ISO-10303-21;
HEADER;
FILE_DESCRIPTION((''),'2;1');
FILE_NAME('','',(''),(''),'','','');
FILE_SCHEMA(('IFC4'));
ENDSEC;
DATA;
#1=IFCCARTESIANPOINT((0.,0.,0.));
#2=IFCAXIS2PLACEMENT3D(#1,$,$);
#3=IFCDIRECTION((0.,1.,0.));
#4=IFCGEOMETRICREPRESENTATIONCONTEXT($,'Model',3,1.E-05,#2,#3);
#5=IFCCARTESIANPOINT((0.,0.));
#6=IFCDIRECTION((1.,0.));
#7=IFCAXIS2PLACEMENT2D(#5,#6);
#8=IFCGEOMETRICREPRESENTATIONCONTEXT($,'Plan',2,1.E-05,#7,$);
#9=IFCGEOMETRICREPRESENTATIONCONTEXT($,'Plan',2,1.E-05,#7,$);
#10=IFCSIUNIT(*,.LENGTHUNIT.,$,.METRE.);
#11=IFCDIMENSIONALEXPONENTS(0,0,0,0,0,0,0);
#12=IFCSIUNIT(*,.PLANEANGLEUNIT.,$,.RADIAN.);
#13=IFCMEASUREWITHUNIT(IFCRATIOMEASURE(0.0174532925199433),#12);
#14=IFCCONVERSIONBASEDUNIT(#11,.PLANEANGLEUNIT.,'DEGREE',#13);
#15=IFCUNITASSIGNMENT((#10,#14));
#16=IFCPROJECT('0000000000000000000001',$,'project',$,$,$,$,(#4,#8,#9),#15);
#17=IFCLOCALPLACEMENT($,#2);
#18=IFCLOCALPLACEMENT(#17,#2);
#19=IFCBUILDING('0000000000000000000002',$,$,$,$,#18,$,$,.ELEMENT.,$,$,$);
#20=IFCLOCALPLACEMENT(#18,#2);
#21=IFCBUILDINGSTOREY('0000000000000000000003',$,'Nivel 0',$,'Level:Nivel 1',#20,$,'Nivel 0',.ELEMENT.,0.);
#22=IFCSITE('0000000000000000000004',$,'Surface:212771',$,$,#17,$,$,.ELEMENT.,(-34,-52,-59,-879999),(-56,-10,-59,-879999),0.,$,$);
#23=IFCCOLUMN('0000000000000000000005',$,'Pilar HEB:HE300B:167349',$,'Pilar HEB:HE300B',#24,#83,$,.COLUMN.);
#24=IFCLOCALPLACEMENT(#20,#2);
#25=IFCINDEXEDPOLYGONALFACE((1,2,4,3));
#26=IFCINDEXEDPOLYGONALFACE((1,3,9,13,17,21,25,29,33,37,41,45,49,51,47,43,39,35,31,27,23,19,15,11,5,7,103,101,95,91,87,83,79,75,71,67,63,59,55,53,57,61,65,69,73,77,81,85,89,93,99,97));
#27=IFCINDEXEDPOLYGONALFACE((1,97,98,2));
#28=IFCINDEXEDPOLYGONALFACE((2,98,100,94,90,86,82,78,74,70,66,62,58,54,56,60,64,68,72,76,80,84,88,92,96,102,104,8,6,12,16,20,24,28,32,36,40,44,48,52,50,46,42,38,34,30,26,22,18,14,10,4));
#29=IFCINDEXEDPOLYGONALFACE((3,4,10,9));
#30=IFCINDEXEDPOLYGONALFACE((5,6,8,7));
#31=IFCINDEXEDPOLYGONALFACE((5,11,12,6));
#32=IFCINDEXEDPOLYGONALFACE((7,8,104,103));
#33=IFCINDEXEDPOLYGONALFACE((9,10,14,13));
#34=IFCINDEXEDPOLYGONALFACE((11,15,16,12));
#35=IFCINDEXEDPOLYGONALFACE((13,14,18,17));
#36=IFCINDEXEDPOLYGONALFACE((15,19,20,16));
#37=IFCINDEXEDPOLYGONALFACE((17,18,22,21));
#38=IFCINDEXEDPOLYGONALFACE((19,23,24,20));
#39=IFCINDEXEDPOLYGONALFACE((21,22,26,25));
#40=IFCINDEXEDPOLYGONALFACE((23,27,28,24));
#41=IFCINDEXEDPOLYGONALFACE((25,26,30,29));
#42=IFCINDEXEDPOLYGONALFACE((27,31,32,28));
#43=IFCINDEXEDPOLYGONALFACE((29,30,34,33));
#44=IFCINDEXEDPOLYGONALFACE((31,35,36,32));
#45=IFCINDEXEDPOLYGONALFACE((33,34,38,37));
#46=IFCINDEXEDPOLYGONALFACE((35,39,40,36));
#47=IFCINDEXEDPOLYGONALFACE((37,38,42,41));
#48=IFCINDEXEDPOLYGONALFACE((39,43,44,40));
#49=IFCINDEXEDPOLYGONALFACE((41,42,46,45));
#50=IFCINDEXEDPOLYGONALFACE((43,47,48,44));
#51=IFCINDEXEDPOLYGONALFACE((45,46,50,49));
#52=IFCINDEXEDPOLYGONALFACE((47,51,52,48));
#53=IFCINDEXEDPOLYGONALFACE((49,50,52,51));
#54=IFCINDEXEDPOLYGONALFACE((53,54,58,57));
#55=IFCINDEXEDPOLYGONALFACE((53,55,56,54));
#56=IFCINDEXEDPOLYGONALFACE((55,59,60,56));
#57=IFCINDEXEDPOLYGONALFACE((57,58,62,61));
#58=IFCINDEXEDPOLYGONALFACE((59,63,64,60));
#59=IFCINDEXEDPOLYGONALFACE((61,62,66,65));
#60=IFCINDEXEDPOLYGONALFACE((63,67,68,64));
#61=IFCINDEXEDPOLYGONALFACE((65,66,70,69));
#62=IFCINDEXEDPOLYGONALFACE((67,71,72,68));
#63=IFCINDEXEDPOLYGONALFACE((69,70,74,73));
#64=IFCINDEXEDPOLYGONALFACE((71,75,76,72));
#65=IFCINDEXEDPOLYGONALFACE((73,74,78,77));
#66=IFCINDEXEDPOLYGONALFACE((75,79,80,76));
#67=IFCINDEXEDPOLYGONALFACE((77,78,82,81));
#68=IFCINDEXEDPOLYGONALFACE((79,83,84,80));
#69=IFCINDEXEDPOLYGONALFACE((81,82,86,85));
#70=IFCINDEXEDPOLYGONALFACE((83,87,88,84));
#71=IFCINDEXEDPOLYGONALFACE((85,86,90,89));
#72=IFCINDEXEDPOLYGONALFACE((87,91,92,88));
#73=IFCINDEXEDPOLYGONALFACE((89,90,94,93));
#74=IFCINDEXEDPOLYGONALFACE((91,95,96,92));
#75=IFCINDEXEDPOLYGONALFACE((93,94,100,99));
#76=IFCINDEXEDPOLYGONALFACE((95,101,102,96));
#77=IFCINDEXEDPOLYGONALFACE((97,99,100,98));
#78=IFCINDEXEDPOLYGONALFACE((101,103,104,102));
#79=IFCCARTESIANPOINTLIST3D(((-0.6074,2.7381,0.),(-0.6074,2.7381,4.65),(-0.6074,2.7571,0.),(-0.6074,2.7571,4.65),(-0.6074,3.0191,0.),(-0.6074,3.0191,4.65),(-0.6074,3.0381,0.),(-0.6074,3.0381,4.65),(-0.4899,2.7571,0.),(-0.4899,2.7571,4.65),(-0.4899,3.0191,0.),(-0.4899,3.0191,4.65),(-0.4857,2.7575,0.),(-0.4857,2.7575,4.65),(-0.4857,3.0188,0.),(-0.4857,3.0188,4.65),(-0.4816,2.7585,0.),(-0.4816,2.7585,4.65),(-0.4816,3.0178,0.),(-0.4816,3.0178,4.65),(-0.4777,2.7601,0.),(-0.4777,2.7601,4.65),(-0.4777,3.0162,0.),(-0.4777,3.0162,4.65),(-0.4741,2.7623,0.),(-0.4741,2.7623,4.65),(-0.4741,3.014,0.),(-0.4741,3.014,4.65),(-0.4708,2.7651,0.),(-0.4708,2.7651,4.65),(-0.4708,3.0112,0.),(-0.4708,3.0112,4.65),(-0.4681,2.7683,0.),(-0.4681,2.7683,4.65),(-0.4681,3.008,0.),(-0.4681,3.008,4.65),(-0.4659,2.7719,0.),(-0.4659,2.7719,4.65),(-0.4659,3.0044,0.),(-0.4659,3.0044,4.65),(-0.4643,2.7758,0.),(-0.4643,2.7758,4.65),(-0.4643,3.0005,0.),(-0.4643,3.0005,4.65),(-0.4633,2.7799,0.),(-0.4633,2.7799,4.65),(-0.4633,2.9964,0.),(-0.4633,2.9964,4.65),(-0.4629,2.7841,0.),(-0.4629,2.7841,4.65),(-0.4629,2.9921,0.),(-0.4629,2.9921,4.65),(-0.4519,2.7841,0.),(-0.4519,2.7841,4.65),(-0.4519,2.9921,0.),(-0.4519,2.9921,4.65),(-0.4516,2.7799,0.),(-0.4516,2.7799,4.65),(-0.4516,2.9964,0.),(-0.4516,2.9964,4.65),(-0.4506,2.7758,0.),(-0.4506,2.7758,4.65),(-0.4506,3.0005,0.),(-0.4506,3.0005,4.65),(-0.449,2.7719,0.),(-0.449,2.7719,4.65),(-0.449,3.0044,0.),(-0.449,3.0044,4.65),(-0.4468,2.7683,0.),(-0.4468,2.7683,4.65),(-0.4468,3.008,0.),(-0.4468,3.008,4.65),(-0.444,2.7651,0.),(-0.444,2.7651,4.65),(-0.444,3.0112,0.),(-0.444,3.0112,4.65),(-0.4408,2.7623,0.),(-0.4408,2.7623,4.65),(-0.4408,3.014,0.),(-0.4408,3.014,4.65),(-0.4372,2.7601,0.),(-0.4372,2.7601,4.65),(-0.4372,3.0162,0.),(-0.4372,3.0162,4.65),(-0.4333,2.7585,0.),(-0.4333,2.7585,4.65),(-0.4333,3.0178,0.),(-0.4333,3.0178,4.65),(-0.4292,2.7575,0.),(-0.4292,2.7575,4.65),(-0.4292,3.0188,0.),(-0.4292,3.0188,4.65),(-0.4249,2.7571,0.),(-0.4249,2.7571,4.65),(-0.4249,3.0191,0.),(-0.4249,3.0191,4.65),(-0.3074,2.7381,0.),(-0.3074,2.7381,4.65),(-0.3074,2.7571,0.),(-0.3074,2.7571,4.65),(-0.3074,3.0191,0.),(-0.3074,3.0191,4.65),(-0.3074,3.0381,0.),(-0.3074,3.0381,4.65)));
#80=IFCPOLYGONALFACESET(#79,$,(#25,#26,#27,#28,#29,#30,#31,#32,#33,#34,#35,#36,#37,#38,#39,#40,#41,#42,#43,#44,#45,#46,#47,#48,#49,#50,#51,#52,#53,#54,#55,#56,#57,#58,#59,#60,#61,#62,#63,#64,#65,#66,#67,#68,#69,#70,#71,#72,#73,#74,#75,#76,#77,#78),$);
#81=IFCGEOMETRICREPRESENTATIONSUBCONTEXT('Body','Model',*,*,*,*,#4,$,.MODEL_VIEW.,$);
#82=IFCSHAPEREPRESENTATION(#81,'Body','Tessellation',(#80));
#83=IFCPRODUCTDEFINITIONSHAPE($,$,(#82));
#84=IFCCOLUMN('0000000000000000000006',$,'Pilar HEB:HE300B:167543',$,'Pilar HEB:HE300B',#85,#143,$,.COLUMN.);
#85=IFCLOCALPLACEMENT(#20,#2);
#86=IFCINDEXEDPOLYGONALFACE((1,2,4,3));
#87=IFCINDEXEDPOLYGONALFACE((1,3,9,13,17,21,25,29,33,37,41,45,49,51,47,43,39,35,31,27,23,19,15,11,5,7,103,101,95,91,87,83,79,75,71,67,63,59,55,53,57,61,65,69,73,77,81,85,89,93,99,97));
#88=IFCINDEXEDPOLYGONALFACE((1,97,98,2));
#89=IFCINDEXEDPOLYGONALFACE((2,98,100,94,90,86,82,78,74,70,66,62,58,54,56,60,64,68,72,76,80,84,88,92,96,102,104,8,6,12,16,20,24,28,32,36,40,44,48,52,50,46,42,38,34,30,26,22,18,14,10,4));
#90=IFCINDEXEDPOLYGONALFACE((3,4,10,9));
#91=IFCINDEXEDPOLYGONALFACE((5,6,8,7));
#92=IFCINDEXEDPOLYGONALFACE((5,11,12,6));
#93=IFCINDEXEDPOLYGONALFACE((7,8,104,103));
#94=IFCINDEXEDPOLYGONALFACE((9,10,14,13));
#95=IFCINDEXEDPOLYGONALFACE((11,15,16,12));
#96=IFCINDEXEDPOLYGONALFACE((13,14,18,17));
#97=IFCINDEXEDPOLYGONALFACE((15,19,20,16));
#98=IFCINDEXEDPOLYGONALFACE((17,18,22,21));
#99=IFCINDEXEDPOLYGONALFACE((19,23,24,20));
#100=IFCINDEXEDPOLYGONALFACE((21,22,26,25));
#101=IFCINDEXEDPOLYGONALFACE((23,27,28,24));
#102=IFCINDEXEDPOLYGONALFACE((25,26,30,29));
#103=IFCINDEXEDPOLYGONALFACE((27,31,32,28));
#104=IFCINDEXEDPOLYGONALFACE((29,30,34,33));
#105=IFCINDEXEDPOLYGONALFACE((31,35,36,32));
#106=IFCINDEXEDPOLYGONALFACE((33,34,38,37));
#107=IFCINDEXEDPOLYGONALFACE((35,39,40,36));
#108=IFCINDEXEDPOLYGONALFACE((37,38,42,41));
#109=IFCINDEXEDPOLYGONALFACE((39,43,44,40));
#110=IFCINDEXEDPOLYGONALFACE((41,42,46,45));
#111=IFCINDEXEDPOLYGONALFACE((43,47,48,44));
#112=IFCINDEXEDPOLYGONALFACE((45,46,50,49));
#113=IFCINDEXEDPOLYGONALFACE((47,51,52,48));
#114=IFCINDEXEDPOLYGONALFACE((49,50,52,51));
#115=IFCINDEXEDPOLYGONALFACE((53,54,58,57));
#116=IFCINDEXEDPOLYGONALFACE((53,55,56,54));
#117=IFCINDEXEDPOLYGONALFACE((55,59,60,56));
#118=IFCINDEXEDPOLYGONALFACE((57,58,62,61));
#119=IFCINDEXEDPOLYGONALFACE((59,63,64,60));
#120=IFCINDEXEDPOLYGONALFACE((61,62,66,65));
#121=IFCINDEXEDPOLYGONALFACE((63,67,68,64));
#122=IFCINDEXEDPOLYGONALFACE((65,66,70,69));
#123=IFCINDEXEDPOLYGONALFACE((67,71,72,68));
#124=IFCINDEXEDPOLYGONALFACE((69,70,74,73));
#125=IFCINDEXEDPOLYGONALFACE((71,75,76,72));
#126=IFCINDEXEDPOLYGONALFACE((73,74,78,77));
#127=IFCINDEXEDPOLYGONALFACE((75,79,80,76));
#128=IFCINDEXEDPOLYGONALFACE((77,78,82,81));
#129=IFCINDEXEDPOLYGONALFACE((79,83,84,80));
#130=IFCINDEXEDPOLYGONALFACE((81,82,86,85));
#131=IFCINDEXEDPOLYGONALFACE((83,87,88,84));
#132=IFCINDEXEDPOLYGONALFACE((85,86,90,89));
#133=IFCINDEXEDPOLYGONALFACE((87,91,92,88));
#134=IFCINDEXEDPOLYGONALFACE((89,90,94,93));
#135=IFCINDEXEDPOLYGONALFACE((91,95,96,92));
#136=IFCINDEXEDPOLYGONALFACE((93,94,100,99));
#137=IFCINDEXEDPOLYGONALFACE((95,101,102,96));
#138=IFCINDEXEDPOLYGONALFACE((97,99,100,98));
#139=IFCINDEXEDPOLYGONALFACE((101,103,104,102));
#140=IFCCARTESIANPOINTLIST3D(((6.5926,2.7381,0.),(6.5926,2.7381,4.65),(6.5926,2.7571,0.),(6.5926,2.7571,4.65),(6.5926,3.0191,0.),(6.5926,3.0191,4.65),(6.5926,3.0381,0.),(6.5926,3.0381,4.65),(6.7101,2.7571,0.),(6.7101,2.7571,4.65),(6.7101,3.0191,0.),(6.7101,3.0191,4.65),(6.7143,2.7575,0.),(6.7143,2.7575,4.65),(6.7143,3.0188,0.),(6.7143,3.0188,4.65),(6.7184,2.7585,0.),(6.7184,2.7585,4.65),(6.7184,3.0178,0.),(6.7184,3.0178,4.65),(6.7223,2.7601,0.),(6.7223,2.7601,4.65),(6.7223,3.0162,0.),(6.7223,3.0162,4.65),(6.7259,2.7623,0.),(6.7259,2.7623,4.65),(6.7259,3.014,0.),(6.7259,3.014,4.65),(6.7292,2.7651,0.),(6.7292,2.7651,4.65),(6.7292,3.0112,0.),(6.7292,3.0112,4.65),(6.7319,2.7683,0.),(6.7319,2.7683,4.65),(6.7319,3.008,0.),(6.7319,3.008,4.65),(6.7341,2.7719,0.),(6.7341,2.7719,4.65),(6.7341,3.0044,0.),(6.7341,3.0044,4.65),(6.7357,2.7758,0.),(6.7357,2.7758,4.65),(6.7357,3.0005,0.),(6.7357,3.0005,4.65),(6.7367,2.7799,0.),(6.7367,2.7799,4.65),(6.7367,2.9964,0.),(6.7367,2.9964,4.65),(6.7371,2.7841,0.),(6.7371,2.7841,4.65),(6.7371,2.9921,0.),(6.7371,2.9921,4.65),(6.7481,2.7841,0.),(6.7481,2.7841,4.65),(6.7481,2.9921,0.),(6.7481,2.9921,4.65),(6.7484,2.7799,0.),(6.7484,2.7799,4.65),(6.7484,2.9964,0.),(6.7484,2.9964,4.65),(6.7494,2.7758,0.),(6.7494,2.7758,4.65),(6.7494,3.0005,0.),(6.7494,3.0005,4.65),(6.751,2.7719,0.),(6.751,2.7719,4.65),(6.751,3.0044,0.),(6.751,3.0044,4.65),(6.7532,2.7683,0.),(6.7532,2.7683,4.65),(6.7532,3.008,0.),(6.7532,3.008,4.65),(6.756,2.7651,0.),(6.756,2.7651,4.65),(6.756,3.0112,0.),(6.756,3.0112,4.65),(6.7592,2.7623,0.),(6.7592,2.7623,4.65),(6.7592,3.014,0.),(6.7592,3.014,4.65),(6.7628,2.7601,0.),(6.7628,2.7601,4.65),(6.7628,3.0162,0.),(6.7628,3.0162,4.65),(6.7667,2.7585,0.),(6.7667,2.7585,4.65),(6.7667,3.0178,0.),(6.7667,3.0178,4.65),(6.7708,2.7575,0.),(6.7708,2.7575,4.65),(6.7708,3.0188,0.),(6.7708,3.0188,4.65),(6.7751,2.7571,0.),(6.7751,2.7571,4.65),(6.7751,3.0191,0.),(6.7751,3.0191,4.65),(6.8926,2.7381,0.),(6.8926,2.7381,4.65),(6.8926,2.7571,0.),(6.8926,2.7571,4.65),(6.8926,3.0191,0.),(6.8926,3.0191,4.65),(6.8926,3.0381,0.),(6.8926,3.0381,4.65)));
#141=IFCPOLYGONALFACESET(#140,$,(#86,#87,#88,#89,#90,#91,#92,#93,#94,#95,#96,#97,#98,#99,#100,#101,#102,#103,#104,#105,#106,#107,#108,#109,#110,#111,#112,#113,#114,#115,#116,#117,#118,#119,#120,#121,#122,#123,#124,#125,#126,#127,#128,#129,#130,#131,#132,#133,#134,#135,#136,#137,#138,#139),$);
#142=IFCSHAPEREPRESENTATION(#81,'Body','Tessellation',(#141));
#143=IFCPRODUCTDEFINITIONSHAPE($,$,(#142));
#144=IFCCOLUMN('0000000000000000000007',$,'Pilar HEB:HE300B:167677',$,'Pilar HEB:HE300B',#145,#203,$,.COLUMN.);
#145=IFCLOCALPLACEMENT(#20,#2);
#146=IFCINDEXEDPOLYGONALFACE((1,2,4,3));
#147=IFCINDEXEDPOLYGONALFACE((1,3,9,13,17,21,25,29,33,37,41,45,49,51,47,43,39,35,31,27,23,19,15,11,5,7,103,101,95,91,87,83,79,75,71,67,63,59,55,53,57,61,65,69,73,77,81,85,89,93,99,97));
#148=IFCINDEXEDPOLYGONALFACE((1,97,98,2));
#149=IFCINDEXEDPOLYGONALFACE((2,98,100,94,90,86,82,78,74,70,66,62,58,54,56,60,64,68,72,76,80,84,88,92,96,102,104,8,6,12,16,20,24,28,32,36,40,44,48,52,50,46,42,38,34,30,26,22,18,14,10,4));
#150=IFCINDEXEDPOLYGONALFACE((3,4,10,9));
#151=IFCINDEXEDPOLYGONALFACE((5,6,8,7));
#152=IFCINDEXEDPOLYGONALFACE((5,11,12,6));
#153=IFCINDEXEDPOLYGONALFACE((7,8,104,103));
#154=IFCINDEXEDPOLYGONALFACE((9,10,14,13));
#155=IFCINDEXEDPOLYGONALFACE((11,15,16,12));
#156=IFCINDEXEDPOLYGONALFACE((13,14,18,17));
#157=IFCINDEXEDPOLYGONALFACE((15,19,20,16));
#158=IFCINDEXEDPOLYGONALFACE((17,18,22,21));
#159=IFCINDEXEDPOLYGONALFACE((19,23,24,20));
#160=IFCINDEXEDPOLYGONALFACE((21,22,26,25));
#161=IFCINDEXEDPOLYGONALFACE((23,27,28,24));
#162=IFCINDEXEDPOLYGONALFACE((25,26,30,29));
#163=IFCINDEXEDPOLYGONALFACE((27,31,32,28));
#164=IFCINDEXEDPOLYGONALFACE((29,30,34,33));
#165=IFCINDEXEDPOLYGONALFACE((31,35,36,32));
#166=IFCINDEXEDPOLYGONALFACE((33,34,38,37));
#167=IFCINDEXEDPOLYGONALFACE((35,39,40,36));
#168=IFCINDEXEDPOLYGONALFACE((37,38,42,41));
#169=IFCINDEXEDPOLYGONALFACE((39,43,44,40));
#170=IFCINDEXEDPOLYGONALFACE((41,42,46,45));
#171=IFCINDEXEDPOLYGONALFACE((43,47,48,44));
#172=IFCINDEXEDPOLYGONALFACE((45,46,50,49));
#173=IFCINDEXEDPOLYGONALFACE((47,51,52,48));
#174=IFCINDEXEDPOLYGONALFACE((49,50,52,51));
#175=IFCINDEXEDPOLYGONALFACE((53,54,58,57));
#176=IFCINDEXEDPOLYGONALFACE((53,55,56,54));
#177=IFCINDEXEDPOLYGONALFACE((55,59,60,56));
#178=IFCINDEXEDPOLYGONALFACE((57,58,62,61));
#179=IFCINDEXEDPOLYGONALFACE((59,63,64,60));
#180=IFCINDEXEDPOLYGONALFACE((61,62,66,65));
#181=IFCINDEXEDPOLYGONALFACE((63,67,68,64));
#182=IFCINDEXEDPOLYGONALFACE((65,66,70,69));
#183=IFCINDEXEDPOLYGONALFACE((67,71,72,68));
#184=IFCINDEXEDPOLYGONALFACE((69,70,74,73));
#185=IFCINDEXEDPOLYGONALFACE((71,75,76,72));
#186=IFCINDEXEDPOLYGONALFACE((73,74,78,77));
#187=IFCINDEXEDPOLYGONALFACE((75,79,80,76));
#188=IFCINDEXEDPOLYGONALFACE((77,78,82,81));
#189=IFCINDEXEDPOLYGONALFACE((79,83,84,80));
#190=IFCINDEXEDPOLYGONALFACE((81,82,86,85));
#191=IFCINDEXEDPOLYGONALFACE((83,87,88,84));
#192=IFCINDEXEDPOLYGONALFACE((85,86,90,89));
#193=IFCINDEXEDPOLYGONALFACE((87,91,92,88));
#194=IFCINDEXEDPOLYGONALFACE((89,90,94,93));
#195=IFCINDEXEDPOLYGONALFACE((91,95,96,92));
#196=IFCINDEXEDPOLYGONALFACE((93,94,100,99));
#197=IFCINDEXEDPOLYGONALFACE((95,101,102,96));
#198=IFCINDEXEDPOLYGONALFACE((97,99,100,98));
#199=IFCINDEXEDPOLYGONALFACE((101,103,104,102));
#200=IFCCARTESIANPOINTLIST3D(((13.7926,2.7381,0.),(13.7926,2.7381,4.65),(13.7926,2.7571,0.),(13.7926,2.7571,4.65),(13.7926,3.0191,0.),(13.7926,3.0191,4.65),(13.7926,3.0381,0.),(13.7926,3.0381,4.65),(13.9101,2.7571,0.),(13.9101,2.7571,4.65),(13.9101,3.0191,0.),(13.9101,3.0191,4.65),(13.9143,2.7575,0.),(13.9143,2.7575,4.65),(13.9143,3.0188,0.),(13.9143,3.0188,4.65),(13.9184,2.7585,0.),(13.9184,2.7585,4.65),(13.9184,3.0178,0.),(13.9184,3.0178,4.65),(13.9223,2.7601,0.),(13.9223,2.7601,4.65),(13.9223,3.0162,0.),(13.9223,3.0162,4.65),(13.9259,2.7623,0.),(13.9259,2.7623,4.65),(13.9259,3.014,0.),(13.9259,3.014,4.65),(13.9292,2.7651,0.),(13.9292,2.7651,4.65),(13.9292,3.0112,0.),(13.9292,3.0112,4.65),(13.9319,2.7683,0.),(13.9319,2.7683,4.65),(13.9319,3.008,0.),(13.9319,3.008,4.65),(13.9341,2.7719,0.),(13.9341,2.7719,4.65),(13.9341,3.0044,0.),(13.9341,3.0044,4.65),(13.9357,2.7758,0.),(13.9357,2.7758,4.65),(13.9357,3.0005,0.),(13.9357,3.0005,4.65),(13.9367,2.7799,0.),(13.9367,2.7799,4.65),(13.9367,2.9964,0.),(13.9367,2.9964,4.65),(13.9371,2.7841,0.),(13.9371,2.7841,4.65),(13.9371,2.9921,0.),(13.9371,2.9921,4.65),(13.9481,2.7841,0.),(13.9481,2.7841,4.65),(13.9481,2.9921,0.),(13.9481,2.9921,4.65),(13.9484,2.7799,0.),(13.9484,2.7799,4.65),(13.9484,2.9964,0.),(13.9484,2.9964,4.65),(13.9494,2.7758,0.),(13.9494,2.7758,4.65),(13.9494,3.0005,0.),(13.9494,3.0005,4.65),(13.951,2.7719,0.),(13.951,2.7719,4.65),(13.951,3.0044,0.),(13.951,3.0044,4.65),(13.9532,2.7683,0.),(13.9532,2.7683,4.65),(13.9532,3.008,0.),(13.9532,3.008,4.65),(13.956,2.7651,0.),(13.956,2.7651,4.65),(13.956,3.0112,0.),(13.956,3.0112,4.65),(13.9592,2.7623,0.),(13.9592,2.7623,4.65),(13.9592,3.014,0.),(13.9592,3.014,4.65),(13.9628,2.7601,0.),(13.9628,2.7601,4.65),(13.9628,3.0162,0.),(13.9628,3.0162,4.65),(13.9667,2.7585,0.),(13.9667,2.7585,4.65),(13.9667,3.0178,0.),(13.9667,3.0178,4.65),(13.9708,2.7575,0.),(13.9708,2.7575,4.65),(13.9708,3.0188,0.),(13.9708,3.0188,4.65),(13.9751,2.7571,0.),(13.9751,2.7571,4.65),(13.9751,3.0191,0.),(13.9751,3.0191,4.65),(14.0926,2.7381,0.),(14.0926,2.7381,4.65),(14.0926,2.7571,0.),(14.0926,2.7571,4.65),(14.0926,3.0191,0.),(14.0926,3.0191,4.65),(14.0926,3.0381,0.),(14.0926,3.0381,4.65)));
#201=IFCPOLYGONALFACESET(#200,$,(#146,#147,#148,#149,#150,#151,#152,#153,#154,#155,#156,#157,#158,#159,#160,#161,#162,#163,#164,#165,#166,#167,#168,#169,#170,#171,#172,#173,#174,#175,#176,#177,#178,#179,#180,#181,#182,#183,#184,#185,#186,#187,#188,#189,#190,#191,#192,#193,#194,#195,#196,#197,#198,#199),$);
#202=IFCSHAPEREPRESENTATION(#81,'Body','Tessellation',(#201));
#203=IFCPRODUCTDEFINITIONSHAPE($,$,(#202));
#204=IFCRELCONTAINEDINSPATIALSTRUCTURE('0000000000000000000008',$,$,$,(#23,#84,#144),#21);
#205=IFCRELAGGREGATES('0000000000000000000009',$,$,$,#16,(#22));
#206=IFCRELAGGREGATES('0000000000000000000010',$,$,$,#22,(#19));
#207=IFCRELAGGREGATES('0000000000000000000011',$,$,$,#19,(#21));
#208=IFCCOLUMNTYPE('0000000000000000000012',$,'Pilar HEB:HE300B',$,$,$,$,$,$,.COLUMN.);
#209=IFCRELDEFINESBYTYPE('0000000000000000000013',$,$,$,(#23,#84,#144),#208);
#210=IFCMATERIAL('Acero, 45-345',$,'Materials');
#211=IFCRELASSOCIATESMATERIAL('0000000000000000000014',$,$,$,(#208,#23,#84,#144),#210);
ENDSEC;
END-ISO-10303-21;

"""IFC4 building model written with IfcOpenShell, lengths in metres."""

from ifc_helpers import new_model, entity, si_unit, converted_unit, direction, frame, origin, origin_2d_with_axis, place, context, subcontext, project, spatial, indexed_curve, outline, extrude, source, transform, mapped, material, type_object, type_shapes, element, save


model = new_model("IFC4")

# Units and contexts
model_context = context("Model", 3, precision=1e-05, world=origin(), true_north=direction((0.0, 1.0, 0.0)))
plan_context_1 = context("Plan", 2, precision=1e-05, world=origin_2d_with_axis())
plan_context_2 = context("Plan", 2, precision=1e-05, world=origin_2d_with_axis())
body_context = subcontext(model_context, "Body", "Model", "MODEL_VIEW")
ifc_project = project(units=[si_unit("LENGTHUNIT", "METRE"), converted_unit("PLANEANGLEUNIT", "DEGREE", entity("IfcRatioMeasure", 0.0174532925199433), si_unit("PLANEANGLEUNIT", "RADIAN"), dimensions=[0, 0, 0, 0, 0, 0, 0])], contexts=[model_context, plan_context_1, plan_context_2])

# Site, building, storey
site_placement = place(None, origin())
site = spatial("IfcSite", under=ifc_project, at=site_placement, Name="Surface:212771", CompositionType="ELEMENT", RefLatitude=(-34, -52, -59, -879999), RefLongitude=(-56, -10, -59, -879999), RefElevation=0.0)
building_placement = place(site_placement, origin())
building = spatial("IfcBuilding", under=site, at=building_placement, CompositionType="ELEMENT")
storey_placement = place(building_placement, origin())
storey = spatial("IfcBuildingStorey", under=building, at=storey_placement, Name="Nivel 0", ObjectType="Level:Nivel 1", LongName="Nivel 0", CompositionType="ELEMENT", Elevation=0.0)

# Columns
ifc_material_1 = material(Name="Acero, 45-345", Category="Materials")
column_type_1 = type_object("IfcColumnType", Name="Pilar HEB:HE300B", PredefinedType="COLUMN", material=ifc_material_1)
shared_shape_1 = source(origin(), body_context, "Body", "SweptSolid", [
    extrude(outline(indexed_curve([(-0.15, -0.15), (-0.131, -0.15), (-0.131, -0.0325), (-0.1307, -0.0283), (-0.1297, -0.0242), (-0.1281, -0.0202), (-0.1258, -0.0166), (-0.1231, -0.0134), (-0.1199, -0.0107), (-0.1163, -0.0084), (-0.1123, -0.0068), (-0.1082, -0.0058), (-0.104, -0.0055), (0.104, -0.0055), (0.1082, -0.0058), (0.1123, -0.0068), (0.1163, -0.0084), (0.1199, -0.0107), (0.1231, -0.0134), (0.1258, -0.0166), (0.1281, -0.0202), (0.1297, -0.0242), (0.1307, -0.0283), (0.131, -0.0325), (0.131, -0.15), (0.15, -0.15), (0.15, 0.15), (0.131, 0.15), (0.131, 0.0325), (0.1307, 0.0283), (0.1297, 0.0242), (0.1281, 0.0202), (0.1258, 0.0166), (0.1231, 0.0134), (0.1199, 0.0107), (0.1163, 0.0084), (0.1123, 0.0068), (0.1082, 0.0058), (0.104, 0.0055), (-0.104, 0.0055), (-0.1082, 0.0058), (-0.1123, 0.0068), (-0.1163, 0.0084), (-0.1199, 0.0107), (-0.1231, 0.0134), (-0.1258, 0.0166), (-0.1281, 0.0202), (-0.1297, 0.0242), (-0.1307, 0.0283), (-0.131, 0.0325), (-0.131, 0.15), (-0.15, 0.15), (-0.15, -0.15)], self_intersect=False)), frame((0.0, 0.0, 0.0), z_axis=(0.0, 0.0, 1.0), x_axis=(0.0, -1.0, 0.0)), (0.0, 0.0, 1.0), 4.65),
])
type_shapes(column_type_1, [shared_shape_1])
for number, where, name in (
    (1, (-0.4574, 2.8881, 0.0), "Pilar HEB:HE300B:167349"),
    (2, (6.7426, 2.8881, 0.0), "Pilar HEB:HE300B:167543"),
    (3, (13.9426, 2.8881, 0.0), "Pilar HEB:HE300B:167677"),
):
    element("IfcColumn", number, at=place(storey_placement, frame(where)), inside=storey, type_object=column_type_1, material=ifc_material_1, Name=name, ObjectType="Pilar HEB:HE300B", PredefinedType="COLUMN", context=body_context, shape_type="MappedRepresentation", body=[
        mapped(shared_shape_1, transform((0.0, 0.0, 0.0), scale=1.0)),
    ])

save(model, "model.ifc")
